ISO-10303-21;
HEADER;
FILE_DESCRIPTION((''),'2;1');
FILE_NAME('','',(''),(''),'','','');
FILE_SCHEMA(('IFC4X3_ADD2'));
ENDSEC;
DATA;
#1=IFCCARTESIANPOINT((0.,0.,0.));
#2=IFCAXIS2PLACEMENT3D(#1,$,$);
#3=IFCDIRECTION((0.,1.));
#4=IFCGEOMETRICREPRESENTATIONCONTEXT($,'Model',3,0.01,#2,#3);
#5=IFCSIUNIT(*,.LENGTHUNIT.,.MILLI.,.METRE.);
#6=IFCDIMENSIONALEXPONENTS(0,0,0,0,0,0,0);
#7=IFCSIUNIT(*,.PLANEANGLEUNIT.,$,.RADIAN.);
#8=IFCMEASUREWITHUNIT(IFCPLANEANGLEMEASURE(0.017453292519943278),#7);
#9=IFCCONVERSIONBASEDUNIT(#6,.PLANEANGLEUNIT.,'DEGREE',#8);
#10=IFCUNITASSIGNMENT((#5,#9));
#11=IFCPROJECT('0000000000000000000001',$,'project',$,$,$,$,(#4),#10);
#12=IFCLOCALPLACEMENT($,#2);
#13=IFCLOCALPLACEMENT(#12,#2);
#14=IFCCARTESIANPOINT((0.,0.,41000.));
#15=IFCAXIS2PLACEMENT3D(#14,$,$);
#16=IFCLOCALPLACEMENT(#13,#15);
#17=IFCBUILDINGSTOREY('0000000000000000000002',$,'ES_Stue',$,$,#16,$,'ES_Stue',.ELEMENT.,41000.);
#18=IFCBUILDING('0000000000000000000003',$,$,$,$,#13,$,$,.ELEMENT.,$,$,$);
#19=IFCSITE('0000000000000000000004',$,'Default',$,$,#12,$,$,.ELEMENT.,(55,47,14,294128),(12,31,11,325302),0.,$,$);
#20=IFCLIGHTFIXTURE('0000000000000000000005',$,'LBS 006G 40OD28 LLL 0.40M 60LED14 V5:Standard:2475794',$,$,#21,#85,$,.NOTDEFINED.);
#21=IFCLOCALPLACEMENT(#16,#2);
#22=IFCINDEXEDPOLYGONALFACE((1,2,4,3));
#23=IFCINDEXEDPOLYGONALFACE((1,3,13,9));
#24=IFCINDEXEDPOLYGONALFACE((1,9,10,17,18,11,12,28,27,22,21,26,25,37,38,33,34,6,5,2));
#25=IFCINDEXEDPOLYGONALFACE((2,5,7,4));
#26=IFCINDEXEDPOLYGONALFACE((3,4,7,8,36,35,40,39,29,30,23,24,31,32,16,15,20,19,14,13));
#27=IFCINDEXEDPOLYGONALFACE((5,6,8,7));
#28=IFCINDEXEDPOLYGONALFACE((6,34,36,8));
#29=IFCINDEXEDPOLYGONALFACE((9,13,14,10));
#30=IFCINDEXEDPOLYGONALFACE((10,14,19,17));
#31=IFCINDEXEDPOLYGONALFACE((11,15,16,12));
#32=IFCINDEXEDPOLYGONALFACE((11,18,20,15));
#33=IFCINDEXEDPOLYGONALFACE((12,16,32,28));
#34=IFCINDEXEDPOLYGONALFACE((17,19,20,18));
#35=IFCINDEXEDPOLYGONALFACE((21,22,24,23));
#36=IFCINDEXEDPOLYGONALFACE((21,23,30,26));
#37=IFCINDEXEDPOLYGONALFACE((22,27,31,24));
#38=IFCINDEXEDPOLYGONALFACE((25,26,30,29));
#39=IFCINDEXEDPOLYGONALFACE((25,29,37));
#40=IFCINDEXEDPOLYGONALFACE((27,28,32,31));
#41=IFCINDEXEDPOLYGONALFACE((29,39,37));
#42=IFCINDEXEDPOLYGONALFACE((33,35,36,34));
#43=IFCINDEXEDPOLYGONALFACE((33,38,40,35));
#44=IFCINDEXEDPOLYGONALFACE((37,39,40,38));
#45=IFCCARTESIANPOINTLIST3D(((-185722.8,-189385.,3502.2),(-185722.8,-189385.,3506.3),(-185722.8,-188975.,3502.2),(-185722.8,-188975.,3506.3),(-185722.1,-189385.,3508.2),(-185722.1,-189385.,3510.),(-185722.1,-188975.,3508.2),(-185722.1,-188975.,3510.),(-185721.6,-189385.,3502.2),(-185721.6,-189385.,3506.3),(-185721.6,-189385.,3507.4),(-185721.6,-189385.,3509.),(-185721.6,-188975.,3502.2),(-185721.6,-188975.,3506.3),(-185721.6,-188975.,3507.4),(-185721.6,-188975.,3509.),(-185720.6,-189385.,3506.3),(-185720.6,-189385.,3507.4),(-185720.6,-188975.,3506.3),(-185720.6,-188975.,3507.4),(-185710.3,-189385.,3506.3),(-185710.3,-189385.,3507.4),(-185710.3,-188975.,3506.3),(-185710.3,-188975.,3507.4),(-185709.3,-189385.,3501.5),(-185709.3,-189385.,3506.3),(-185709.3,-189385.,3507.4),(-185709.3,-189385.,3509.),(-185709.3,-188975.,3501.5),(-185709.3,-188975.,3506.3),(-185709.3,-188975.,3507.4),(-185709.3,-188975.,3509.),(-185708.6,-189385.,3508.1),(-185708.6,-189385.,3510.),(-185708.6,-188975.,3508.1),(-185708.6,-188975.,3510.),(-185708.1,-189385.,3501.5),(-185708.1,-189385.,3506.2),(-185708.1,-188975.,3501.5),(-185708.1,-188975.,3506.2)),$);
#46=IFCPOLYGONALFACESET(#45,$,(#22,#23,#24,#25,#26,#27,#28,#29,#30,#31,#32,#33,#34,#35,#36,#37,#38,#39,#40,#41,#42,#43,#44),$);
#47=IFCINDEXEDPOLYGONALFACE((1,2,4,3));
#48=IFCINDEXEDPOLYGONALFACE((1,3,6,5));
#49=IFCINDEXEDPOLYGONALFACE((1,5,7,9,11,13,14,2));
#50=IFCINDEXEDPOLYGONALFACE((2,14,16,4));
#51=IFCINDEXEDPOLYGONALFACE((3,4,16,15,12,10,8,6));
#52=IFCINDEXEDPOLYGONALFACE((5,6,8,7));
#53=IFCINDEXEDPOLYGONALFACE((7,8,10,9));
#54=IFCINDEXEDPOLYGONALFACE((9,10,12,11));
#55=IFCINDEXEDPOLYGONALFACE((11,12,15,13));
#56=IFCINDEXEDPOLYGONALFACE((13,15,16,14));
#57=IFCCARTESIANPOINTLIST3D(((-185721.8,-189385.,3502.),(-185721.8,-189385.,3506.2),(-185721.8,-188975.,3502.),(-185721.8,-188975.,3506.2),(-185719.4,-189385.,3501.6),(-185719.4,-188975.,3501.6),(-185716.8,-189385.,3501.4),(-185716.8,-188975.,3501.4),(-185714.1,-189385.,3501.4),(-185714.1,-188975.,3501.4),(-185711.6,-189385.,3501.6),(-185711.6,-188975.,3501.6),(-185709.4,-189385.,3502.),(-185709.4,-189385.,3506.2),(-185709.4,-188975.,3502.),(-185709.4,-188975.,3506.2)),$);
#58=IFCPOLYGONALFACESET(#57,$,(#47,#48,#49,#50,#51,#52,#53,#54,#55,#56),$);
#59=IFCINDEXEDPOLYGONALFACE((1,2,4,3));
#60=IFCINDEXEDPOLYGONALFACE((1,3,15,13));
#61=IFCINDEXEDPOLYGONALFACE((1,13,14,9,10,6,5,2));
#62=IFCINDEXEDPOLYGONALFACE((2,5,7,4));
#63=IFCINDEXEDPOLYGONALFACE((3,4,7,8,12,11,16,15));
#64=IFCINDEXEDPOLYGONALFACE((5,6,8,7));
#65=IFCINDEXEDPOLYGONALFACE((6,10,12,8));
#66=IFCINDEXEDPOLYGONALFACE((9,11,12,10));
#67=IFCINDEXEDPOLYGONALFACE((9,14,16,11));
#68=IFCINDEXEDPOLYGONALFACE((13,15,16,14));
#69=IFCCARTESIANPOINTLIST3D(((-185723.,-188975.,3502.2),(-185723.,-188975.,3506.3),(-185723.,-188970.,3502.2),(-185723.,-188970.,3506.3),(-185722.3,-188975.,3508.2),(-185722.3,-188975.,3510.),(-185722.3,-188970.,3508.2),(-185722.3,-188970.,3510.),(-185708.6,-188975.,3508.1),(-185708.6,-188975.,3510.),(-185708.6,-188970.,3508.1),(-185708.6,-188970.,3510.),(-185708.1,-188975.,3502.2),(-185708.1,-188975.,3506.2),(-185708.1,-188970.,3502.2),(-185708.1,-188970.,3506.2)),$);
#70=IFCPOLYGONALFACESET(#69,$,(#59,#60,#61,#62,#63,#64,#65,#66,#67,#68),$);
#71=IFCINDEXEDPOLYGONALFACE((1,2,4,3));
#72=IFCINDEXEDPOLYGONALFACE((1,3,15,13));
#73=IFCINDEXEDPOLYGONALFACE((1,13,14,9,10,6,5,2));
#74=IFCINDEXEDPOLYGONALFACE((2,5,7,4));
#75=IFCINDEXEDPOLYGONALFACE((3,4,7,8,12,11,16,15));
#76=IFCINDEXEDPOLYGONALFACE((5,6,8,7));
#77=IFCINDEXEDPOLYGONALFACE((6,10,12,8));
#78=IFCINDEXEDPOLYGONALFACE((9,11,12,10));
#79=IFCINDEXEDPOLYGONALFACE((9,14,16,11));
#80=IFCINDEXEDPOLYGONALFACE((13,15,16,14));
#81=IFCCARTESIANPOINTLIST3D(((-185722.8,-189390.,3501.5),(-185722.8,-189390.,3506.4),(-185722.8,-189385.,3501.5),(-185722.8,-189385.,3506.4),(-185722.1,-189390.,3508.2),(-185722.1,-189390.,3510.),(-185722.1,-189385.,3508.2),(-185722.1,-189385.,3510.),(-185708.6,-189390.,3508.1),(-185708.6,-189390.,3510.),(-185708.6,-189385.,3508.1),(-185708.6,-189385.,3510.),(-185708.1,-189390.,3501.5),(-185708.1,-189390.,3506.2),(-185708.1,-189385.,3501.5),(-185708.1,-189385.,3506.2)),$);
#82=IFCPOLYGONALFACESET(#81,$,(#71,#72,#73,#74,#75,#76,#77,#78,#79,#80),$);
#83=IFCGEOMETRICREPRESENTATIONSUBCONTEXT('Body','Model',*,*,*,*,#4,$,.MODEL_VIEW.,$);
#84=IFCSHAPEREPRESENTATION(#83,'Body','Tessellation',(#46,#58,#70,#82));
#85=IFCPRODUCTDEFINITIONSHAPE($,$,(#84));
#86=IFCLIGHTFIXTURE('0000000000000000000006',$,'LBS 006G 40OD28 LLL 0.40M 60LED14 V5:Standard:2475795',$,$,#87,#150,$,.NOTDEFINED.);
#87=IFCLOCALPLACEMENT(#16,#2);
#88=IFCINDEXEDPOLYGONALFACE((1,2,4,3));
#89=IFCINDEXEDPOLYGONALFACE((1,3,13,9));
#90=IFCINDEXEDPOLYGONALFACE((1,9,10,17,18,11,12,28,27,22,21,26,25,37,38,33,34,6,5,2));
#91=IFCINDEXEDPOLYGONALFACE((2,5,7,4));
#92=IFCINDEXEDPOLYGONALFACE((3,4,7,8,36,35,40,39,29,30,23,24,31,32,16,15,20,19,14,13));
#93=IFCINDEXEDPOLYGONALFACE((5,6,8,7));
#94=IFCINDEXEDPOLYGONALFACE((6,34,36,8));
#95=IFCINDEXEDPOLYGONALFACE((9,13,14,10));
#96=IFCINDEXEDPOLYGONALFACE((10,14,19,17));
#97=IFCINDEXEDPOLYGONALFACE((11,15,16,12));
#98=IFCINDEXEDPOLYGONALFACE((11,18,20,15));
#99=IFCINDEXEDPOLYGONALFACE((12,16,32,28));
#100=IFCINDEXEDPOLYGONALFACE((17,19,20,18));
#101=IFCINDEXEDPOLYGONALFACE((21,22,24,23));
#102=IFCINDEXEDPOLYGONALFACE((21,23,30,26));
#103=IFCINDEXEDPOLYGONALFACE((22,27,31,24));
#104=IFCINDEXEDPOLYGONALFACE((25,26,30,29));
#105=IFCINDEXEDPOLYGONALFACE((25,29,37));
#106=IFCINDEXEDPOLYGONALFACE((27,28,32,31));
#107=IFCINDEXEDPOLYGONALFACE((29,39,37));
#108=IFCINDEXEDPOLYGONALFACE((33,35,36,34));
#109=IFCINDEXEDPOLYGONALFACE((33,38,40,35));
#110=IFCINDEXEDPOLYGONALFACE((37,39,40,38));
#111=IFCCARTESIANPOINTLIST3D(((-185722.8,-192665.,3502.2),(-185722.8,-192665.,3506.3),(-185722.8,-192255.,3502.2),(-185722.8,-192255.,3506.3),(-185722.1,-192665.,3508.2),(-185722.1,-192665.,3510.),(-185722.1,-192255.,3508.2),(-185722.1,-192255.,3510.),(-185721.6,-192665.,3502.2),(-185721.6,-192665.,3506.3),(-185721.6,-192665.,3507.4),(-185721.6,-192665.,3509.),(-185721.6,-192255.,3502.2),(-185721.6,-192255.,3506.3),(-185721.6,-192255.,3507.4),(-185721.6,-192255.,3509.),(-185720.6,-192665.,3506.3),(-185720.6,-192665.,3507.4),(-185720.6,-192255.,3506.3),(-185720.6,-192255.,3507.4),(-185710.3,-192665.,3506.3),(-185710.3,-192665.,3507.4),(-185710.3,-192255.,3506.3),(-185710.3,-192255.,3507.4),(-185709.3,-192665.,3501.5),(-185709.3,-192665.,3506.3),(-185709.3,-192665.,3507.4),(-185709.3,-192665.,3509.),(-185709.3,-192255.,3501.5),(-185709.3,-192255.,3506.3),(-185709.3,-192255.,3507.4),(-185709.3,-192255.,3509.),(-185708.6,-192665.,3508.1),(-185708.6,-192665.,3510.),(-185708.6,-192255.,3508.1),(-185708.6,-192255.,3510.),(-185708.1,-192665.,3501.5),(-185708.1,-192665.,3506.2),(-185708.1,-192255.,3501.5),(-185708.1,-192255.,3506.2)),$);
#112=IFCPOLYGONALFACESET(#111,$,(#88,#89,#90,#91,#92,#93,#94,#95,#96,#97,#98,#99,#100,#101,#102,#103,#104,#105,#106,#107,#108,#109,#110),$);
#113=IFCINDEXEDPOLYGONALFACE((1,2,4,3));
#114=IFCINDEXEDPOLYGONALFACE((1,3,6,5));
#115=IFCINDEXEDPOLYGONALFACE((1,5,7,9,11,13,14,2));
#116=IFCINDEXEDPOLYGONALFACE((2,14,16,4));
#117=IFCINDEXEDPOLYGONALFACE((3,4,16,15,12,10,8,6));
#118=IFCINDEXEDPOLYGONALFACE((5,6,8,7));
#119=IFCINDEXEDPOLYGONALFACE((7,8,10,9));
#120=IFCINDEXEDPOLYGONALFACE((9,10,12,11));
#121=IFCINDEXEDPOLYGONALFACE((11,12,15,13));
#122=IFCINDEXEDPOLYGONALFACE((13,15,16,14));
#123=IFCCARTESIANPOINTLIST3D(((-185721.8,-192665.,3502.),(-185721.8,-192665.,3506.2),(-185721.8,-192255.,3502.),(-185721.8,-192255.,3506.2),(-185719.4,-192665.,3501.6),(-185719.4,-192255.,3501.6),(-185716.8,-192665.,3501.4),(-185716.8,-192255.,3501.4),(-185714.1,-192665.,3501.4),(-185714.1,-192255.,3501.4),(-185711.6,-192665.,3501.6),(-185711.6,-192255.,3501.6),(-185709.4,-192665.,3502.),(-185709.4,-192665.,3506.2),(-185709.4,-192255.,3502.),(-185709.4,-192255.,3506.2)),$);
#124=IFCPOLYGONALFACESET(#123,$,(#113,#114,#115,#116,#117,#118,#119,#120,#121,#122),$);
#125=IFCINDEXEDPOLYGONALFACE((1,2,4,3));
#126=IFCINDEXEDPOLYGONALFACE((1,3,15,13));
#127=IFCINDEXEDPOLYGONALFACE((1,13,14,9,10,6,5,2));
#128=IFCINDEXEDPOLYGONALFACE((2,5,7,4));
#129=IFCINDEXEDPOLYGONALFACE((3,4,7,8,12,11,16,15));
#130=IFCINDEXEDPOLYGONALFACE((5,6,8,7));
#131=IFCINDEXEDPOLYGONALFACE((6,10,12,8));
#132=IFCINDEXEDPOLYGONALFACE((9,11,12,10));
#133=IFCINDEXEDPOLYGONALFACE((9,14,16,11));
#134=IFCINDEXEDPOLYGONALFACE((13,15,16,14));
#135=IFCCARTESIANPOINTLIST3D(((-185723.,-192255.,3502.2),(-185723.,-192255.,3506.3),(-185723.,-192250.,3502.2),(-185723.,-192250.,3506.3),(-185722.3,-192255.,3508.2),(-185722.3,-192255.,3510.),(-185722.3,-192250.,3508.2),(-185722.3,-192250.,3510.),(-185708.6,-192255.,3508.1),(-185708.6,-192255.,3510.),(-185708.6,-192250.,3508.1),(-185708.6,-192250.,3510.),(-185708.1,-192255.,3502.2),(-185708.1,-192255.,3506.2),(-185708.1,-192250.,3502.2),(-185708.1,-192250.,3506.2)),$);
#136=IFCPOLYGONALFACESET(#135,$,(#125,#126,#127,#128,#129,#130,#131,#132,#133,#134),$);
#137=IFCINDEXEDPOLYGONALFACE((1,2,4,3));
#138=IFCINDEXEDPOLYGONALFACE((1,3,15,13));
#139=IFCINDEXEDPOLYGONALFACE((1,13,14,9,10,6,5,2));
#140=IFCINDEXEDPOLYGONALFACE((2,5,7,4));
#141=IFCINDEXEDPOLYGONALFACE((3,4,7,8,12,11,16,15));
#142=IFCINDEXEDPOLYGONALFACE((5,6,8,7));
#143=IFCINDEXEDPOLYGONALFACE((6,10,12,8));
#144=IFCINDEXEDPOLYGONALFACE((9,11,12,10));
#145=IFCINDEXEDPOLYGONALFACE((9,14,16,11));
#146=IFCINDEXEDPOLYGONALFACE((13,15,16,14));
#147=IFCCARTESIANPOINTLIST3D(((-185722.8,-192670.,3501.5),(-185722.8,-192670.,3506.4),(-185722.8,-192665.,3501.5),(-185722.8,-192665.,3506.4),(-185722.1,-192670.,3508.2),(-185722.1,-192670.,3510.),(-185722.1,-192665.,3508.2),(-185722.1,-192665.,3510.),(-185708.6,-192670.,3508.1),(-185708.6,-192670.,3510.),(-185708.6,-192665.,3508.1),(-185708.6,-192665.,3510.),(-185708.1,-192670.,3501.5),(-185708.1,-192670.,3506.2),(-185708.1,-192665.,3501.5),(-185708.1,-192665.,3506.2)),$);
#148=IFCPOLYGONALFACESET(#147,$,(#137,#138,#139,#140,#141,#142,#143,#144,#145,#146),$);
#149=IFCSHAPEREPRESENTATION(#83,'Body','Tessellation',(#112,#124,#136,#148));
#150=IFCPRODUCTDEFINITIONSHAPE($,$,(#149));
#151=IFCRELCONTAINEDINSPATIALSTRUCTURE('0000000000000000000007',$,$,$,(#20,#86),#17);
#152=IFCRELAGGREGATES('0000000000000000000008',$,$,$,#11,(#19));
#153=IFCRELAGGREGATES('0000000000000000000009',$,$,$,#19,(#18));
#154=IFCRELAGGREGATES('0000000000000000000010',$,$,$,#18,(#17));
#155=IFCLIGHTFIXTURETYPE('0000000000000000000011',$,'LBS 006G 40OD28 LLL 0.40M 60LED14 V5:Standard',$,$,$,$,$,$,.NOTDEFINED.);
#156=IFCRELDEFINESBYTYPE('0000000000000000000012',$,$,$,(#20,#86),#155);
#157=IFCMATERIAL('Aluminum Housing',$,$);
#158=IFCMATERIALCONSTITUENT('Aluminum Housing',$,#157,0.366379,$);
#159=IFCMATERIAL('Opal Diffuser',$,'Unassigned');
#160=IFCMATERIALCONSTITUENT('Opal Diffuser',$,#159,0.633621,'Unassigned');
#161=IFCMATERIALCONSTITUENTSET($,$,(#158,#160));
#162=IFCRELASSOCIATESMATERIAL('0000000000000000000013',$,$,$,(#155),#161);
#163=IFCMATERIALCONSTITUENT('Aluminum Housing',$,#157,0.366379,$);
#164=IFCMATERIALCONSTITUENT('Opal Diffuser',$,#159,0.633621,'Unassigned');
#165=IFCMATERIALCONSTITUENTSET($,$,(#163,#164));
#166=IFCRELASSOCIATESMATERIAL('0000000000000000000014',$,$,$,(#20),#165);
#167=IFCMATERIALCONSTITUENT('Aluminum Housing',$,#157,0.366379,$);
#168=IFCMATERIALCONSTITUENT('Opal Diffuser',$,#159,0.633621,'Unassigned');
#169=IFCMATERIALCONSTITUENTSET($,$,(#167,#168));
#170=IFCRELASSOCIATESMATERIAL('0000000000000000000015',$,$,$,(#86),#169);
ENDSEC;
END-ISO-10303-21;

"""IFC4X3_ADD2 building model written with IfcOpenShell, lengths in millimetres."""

from ifc_helpers import new_model, entity, si_unit, converted_unit, direction, frame, origin, place, context, subcontext, project, spatial, polyline, outline, extrude, source, transform, mapped, material, constituent, constituent_set, type_object, type_shapes, element, save


model = new_model("IFC4X3_ADD2")

# Units and contexts
model_context = context("Model", 3, precision=0.01, world=origin(), true_north=direction((0.0, 1.0)))
body_context = subcontext(model_context, "Body", "Model", "MODEL_VIEW")
ifc_project = project(units=[si_unit("LENGTHUNIT", "METRE", prefix="MILLI"), converted_unit("PLANEANGLEUNIT", "DEGREE", entity("IfcPlaneAngleMeasure", 0.017453292519943278), si_unit("PLANEANGLEUNIT", "RADIAN"), dimensions=[0, 0, 0, 0, 0, 0, 0])], contexts=[model_context])

# Site, building, storey
site_placement = place(None, origin())
site = spatial("IfcSite", under=ifc_project, at=site_placement, Name="Default", CompositionType="ELEMENT", RefLatitude=(55, 47, 14, 294128), RefLongitude=(12, 31, 11, 325302), RefElevation=0.0)
building_placement = place(site_placement, origin())
building = spatial("IfcBuilding", under=site, at=building_placement, CompositionType="ELEMENT")
storey_placement = place(building_placement, frame((0.0, 0.0, 41000.0)))
storey = spatial("IfcBuildingStorey", under=building, at=storey_placement, Name="ES_Stue", LongName="ES_Stue", CompositionType="ELEMENT", Elevation=41000.0)

# Light fixtures
ifc_material_1 = material(Name="Aluminum Housing")
ifc_constituent_1 = constituent(ifc_material_1, Name="Aluminum Housing", fraction=0.366379)
ifc_material_2 = material(Name="Opal Diffuser", Category="Unassigned")
ifc_constituent_2 = constituent(ifc_material_2, Name="Opal Diffuser", Category="Unassigned", fraction=0.633621)
ifc_constituent_set_1 = constituent_set(constituents=[ifc_constituent_1, ifc_constituent_2])
ifc_constituent_3 = constituent(ifc_material_1, Name="Aluminum Housing", fraction=0.366379)
ifc_constituent_4 = constituent(ifc_material_2, Name="Opal Diffuser", Category="Unassigned", fraction=0.633621)
ifc_constituent_set_2 = constituent_set(constituents=[ifc_constituent_3, ifc_constituent_4])
light_fixture_type = type_object("IfcLightFixtureType", Name="LBS 006G 40OD28 LLL 0.40M 60LED14 V5:Standard", PredefinedType="NOTDEFINED", material=ifc_constituent_set_2)
shared_shape_1 = source(origin(), body_context, "Body", "SweptSolid", [
    extrude(outline(polyline([(-5.0, -6.1), (-5.0, -7.4), (-0.3, -7.4), (1.7, -6.8), (3.5, -6.8), (3.5, 6.7), (1.8, 6.7), (-0.1, 7.3), (-4.2, 7.3), (-4.2, 6.2), (-0.1, 6.2), (-0.1, 5.2), (0.9, 5.2), (0.9, 6.2), (2.5, 6.2), (2.5, -6.1), (0.9, -6.1), (0.9, -5.1), (-0.1, -5.1), (-0.1, -6.1), (-5.0, -6.1)])), frame((-205.0, 0.1, 3.5), z_axis=(-1.0, 0.0, 0.0), x_axis=(0.0, 0.0, -1.0)), (0.0, 0.0, -1.0), 410.0),
    extrude(outline(polyline([(-0.8, -6.2), (3.4, -6.2), (3.4, 6.2), (-0.8, 6.2), (-1.2, 3.9), (-1.4, 1.4), (-1.4, -1.3), (-1.2, -3.9), (-0.8, -6.2)])), frame((-205.0, 0.0, 7.2), z_axis=(1.0, 0.0, 0.0), x_axis=(0.0, 0.0, -1.0)), (0.0, 0.0, 1.0), 410.0),
    extrude(outline(polyline([(-4.4, -7.5), (-0.3, -7.5), (1.5, -6.8), (3.3, -6.8), (3.3, 6.9), (1.5, 6.9), (-0.5, 7.4), (-4.4, 7.4), (-4.4, -7.5)])), frame((205.0, 0.0, 3.3), z_axis=(1.0, 0.0, 0.0), x_axis=(0.0, 0.0, -1.0)), (0.0, 0.0, 1.0), 5.0),
    extrude(outline(polyline([(-5.0, -7.4), (-0.1, -7.4), (1.7, -6.7), (3.5, -6.7), (3.5, 6.8), (1.6, 6.8), (-0.3, 7.3), (-5.0, 7.3), (-5.0, -7.4)])), frame((-210.0, 0.2, 3.5), z_axis=(1.0, 0.0, 0.0), x_axis=(0.0, 0.0, -1.0)), (0.0, 0.0, 1.0), 5.0),
])
type_shapes(light_fixture_type, [shared_shape_1])
light_fixture_1_placement = place(storey_placement, frame((-185715.5, -189180.0, 3510.0), z_axis=(0.0, 0.0, -1.0), x_axis=(0.0, 1.0, 0.0)))
element("IfcLightFixture", 1, at=light_fixture_1_placement, inside=storey, type_object=light_fixture_type, material=ifc_constituent_set_1, Name="LBS 006G 40OD28 LLL 0.40M 60LED14 V5:Standard:2475794", PredefinedType="NOTDEFINED", context=body_context, shape_type="MappedRepresentation", body=[
    mapped(shared_shape_1, transform((0.0, 0.0, 0.0), scale=1.0)),
])
ifc_constituent_5 = constituent(ifc_material_1, Name="Aluminum Housing", fraction=0.366379)
ifc_constituent_6 = constituent(ifc_material_2, Name="Opal Diffuser", Category="Unassigned", fraction=0.633621)
ifc_constituent_set_3 = constituent_set(constituents=[ifc_constituent_5, ifc_constituent_6])
light_fixture_2_placement = place(storey_placement, frame((-185715.5, -192460.0, 3510.0), z_axis=(0.0, 0.0, -1.0), x_axis=(0.0, 1.0, 0.0)))
element("IfcLightFixture", 2, at=light_fixture_2_placement, inside=storey, type_object=light_fixture_type, material=ifc_constituent_set_3, Name="LBS 006G 40OD28 LLL 0.40M 60LED14 V5:Standard:2475795", PredefinedType="NOTDEFINED", context=body_context, shape_type="MappedRepresentation", body=[
    mapped(shared_shape_1, transform((0.0, 0.0, 0.0), scale=1.0)),
])

save(model, "model.ifc")
